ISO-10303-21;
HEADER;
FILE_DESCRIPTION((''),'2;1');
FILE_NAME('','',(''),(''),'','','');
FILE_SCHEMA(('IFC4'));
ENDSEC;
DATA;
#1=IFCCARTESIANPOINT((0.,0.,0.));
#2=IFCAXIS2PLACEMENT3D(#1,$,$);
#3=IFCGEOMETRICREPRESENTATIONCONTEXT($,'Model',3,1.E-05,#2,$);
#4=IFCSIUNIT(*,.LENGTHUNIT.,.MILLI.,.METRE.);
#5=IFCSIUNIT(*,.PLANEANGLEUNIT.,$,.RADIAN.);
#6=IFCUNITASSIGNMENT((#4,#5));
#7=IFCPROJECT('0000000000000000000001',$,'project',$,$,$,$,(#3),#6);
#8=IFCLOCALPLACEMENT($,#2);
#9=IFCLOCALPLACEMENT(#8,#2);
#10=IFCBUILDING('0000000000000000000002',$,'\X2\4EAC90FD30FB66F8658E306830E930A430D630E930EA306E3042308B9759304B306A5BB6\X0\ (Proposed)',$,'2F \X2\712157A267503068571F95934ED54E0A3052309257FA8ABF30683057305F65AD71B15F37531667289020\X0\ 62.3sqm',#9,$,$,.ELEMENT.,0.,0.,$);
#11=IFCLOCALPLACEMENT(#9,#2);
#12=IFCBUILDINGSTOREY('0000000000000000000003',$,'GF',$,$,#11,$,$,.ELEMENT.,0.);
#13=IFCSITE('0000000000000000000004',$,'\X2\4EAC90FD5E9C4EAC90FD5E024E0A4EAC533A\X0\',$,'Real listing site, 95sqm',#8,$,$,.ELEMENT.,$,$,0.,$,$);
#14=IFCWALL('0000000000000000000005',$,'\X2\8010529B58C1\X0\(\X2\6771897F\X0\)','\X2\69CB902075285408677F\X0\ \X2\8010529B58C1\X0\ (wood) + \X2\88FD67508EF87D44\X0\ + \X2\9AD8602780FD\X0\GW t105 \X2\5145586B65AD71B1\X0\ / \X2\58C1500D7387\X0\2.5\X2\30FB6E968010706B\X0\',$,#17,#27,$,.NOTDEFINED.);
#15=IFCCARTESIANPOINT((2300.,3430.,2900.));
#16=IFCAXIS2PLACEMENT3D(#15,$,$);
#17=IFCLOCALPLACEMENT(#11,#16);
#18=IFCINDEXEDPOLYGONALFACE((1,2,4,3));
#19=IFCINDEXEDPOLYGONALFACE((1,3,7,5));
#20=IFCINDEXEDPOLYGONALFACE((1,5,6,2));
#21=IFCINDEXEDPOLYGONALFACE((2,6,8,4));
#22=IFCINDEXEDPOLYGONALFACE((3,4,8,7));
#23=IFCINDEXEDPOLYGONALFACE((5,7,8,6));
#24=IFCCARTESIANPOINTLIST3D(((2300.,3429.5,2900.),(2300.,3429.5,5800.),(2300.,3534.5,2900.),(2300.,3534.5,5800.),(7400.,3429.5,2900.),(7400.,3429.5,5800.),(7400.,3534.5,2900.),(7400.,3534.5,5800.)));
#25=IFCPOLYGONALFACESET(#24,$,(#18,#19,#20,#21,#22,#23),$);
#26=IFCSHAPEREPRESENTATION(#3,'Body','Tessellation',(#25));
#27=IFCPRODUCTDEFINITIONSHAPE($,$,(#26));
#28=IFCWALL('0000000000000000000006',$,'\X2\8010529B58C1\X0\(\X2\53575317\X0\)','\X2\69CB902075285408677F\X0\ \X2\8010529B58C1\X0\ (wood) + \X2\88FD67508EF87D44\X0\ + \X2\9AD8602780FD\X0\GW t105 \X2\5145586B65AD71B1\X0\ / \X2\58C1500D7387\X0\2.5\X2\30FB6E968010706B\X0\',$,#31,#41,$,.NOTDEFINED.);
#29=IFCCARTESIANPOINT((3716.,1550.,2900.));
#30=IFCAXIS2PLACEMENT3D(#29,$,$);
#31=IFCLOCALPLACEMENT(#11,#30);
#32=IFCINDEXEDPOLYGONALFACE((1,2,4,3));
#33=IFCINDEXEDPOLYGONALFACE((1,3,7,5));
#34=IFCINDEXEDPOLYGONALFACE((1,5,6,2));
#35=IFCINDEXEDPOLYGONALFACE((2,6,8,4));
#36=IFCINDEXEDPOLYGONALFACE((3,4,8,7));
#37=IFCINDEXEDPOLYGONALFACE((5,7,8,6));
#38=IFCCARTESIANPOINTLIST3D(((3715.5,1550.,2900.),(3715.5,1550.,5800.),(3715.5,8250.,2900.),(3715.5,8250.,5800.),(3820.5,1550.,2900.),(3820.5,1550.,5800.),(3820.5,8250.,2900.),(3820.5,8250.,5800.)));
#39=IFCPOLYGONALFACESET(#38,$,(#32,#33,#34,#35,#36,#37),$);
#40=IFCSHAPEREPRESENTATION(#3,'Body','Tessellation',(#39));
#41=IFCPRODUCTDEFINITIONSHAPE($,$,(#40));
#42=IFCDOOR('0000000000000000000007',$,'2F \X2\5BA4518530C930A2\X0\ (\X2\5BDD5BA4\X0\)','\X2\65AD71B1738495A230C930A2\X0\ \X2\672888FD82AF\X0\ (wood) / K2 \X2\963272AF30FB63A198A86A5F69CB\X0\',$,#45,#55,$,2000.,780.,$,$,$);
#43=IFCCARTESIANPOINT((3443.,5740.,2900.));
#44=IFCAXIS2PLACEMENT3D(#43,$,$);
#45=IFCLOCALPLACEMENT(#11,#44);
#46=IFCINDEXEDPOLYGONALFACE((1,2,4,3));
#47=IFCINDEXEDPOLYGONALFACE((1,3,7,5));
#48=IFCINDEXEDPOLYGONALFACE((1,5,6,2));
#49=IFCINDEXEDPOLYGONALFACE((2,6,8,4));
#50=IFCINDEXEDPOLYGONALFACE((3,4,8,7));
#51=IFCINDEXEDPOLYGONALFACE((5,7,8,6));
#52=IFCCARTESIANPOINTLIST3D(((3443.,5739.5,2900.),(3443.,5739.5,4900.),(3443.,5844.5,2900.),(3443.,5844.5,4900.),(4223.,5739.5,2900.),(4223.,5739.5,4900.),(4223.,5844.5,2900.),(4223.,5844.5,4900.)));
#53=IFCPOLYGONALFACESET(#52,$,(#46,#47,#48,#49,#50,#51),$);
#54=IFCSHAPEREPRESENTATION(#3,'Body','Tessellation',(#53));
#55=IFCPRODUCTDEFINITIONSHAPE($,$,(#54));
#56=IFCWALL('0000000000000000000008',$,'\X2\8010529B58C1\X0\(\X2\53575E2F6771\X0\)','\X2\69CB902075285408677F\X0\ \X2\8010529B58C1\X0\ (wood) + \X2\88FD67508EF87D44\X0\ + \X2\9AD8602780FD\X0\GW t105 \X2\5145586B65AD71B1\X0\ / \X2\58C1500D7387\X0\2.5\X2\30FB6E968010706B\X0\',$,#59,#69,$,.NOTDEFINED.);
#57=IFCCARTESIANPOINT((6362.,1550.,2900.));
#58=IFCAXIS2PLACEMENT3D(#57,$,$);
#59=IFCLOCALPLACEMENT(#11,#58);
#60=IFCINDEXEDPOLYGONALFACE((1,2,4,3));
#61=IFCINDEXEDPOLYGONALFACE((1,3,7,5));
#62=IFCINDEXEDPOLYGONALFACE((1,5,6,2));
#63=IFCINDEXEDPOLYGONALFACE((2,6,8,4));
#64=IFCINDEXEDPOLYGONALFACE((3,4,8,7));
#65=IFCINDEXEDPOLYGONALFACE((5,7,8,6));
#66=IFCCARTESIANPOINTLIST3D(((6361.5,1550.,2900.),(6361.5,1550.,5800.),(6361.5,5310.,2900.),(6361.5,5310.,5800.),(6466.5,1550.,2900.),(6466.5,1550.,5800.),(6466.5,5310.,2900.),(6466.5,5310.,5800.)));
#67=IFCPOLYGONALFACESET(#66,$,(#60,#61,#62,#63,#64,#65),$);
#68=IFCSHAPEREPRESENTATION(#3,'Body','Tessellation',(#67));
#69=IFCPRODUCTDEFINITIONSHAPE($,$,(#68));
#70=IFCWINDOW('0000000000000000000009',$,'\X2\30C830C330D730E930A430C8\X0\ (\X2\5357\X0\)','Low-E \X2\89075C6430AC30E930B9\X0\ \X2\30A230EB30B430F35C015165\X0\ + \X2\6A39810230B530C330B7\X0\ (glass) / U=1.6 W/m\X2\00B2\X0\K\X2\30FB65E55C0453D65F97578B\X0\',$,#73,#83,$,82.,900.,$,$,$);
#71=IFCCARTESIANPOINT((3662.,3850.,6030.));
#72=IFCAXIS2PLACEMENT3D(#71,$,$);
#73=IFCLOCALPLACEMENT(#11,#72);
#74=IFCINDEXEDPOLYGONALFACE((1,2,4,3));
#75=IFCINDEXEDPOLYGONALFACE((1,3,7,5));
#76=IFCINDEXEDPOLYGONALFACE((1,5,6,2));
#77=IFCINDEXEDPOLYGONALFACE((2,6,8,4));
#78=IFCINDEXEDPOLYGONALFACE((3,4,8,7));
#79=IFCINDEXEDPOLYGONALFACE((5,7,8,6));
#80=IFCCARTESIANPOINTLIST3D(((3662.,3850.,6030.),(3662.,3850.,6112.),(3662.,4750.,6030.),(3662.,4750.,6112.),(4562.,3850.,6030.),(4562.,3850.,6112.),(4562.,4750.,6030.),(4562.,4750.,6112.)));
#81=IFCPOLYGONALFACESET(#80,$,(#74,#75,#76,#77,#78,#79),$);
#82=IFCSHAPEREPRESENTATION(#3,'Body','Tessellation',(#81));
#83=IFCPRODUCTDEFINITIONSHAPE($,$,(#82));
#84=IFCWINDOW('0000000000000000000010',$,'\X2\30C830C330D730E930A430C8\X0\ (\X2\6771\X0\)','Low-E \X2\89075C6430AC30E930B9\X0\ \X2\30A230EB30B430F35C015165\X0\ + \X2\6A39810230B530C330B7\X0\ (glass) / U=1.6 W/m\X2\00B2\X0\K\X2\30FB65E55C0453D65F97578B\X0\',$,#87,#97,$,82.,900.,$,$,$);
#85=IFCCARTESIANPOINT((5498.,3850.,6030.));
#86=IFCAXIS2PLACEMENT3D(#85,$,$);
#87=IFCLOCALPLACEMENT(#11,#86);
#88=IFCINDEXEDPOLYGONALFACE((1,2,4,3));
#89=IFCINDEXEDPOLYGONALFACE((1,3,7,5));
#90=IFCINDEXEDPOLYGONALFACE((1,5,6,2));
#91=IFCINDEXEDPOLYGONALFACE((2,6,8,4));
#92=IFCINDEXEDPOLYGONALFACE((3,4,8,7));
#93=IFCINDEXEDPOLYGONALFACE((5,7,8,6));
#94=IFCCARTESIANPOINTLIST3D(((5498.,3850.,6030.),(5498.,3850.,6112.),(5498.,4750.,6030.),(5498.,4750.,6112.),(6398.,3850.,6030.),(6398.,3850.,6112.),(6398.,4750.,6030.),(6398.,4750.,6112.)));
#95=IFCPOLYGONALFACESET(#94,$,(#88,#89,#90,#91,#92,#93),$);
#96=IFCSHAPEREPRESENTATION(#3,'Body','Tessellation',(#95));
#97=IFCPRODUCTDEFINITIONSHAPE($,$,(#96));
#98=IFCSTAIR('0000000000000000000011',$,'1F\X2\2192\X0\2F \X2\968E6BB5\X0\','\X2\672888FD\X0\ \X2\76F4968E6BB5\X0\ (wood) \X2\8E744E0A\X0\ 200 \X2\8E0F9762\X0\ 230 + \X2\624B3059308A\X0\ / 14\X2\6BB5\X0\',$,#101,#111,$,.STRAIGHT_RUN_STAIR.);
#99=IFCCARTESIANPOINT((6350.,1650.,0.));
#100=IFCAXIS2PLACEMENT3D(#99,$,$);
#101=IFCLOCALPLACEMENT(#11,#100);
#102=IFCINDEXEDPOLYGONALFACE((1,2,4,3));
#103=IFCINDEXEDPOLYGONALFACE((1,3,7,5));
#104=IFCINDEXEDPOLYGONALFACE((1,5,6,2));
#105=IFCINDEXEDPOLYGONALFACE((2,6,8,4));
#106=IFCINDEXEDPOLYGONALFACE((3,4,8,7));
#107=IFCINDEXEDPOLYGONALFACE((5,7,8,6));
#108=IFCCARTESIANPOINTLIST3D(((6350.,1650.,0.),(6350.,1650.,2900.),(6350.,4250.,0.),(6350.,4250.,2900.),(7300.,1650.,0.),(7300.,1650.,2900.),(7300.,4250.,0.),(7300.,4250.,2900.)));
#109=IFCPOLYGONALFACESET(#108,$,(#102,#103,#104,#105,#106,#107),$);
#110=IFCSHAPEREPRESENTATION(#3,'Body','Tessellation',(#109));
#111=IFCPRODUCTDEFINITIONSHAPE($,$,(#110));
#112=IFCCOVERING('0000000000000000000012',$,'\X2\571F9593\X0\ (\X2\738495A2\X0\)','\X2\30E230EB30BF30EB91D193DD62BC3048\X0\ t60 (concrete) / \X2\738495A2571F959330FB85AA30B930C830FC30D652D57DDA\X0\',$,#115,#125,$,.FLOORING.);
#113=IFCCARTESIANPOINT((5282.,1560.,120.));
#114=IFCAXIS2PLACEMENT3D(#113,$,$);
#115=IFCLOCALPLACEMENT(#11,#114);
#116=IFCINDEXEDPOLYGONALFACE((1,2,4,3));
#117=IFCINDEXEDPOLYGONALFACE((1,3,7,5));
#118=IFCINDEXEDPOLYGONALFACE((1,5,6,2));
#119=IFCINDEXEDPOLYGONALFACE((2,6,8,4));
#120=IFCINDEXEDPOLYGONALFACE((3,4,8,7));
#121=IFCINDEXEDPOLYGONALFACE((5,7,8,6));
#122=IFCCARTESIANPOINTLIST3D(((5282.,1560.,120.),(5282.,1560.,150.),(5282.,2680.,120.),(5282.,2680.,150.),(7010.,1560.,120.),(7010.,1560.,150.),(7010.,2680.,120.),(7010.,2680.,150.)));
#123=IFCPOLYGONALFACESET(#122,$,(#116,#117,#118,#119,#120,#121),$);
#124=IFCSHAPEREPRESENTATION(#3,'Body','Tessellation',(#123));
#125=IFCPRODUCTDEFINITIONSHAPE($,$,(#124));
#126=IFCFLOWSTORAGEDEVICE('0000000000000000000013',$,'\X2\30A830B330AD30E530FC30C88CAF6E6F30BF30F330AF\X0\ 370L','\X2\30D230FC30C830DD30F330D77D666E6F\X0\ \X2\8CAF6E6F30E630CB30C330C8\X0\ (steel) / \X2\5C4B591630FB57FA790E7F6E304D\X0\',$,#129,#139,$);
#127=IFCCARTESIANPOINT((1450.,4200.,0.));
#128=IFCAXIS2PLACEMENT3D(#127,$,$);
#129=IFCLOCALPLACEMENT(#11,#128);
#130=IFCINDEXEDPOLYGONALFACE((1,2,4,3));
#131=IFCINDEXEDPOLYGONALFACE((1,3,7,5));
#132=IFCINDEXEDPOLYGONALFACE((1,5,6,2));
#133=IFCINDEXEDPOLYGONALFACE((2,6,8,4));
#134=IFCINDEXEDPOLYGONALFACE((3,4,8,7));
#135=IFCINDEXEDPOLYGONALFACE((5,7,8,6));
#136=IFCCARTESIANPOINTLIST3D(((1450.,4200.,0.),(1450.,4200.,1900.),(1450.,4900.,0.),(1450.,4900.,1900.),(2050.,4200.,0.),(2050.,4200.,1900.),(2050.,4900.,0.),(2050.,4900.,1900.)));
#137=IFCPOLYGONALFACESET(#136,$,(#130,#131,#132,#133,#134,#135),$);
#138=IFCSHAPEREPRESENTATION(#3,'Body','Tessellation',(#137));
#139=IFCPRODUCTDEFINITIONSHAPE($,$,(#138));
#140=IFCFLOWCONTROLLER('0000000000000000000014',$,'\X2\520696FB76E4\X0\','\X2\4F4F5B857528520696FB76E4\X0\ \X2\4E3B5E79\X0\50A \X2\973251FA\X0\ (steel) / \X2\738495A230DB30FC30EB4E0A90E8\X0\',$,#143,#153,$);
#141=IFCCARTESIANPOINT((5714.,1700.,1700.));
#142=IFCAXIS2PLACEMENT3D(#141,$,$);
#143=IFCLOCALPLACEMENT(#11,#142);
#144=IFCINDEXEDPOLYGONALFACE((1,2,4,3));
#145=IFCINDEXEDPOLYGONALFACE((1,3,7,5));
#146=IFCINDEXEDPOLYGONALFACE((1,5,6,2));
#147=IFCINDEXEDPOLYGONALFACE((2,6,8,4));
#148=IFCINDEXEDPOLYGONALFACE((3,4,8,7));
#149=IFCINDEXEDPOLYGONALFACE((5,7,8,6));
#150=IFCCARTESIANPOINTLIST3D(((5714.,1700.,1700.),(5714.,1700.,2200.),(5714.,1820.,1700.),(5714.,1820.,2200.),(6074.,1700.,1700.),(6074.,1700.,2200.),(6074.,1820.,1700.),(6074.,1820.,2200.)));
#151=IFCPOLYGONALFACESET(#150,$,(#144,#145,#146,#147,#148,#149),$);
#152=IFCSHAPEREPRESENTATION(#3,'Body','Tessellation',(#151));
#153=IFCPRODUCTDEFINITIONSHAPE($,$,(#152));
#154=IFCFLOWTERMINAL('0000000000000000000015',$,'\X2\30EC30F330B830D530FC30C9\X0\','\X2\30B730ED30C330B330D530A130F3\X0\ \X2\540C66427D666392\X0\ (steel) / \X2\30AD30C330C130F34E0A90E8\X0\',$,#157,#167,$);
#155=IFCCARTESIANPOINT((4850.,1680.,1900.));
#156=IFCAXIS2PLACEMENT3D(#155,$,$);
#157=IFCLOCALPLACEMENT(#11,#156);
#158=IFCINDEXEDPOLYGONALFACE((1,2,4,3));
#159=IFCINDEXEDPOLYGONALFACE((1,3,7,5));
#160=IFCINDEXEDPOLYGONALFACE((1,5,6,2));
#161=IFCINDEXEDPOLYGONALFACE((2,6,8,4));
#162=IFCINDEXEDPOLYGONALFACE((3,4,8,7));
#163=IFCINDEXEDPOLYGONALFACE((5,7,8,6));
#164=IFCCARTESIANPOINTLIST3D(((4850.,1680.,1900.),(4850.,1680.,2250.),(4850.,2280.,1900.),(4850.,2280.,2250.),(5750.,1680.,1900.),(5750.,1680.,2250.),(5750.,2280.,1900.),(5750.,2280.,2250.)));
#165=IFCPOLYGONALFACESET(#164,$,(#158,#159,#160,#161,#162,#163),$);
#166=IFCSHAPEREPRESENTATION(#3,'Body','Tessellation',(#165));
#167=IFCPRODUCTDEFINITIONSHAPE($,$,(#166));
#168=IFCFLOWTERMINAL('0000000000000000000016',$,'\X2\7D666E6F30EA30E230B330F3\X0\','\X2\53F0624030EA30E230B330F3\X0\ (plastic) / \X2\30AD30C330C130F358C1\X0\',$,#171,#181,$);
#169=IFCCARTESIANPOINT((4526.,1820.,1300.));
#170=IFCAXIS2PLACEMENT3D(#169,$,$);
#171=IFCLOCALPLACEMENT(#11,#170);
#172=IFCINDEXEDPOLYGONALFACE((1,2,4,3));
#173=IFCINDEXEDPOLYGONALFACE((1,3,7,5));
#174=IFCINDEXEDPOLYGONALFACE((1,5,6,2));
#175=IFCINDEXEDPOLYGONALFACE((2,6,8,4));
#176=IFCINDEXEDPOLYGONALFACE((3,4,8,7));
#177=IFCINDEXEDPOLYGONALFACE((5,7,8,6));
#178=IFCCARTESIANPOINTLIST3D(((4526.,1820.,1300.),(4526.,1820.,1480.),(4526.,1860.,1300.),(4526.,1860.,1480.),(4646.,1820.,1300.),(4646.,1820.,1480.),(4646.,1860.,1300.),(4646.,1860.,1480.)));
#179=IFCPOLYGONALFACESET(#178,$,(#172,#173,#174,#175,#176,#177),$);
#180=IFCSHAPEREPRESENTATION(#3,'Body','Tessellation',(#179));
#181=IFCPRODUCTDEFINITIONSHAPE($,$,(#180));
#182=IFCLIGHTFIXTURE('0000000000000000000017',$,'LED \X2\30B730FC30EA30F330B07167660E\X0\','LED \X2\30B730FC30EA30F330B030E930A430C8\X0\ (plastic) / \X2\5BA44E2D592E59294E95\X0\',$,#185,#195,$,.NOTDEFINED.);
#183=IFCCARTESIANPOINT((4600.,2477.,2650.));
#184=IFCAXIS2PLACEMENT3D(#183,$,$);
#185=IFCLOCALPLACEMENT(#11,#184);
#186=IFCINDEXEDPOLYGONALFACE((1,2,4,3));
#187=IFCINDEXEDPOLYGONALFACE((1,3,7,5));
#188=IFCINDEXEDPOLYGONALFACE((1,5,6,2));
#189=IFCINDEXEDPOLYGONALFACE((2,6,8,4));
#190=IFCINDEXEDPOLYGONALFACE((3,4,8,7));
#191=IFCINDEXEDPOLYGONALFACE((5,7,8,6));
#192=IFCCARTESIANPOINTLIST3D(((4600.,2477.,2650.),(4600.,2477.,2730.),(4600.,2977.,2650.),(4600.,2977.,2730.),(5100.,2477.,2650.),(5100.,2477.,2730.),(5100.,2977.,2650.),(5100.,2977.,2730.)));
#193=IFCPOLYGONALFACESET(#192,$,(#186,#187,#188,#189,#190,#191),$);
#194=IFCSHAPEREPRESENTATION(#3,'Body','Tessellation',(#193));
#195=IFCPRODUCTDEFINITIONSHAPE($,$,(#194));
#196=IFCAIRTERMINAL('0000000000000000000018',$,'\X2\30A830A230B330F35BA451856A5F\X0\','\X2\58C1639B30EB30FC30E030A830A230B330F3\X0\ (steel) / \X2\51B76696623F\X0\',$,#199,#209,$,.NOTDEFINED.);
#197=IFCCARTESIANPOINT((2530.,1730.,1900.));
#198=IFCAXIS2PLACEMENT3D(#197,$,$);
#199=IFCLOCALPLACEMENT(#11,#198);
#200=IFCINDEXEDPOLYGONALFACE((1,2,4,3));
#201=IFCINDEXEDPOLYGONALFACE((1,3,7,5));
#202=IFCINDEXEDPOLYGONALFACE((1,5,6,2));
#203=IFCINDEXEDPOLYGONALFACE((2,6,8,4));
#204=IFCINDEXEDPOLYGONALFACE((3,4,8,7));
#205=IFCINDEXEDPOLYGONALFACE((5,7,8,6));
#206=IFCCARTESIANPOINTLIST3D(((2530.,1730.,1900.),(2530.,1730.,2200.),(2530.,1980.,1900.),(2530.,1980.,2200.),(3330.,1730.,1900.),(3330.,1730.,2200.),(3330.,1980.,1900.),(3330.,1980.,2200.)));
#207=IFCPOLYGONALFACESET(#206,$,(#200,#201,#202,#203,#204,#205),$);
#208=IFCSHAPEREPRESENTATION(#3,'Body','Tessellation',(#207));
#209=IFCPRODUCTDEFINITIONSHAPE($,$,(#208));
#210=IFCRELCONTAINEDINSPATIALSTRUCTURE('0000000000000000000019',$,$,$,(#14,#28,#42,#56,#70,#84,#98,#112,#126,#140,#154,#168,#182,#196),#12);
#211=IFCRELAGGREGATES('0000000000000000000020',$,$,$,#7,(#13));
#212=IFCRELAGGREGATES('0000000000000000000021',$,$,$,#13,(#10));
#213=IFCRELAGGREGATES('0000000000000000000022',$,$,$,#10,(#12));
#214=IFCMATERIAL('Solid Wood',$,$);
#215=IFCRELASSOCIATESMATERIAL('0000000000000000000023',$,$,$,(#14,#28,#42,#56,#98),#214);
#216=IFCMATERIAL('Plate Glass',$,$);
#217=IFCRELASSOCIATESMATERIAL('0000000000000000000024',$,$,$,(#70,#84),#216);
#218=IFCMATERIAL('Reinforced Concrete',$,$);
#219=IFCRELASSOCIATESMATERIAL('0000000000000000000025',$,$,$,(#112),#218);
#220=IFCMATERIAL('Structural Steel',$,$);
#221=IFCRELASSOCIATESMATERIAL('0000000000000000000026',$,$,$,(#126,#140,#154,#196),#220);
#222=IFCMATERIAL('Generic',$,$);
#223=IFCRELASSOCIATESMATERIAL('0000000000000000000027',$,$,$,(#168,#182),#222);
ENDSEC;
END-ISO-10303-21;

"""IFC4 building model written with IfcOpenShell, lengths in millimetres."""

from ifc_helpers import new_model, si_unit, frame, frame_2d, origin, place, context, project, spatial, rectangle, extrude, material, element, fill, save


model = new_model("IFC4")

# Units and contexts
model_context = context("Model", 3, precision=1e-05, world=origin())
ifc_project = project(units=[si_unit("LENGTHUNIT", "METRE", prefix="MILLI"), si_unit("PLANEANGLEUNIT", "RADIAN")], contexts=[model_context])

# Site, building, storey
site_placement = place(None, origin())
site = spatial("IfcSite", under=ifc_project, at=site_placement, Name="京都府京都市上京区", ObjectType="Real listing site, 95sqm", CompositionType="ELEMENT", RefElevation=0.0)
building_placement = place(site_placement, origin())
building = spatial("IfcBuilding", under=site, at=building_placement, Name="京都・書斎とライブラリのある静かな家 (Proposed)", ObjectType="2F 無垢材と土間仕上げを基調とした断熱強化木造 62.3sqm", CompositionType="ELEMENT", ElevationOfRefHeight=0.0, ElevationOfTerrain=0.0)
storey_placement = place(building_placement, origin())
storey = spatial("IfcBuildingStorey", under=building, at=storey_placement, Name="GF", CompositionType="ELEMENT", Elevation=0.0)

# Shared definitions
ifc_material_1 = material(Name="Solid Wood")

# Wall
wall_1_placement = place(storey_placement, frame((2300.0, 3430.0, 2900.0)))
element("IfcWall", 1, at=wall_1_placement, inside=storey, material=ifc_material_1, Name="耐力壁(東西)", Description="構造用合板 耐力壁 (wood) + 製材軸組 + 高性能GW t105 充填断熱 / 壁倍率2.5・準耐火", PredefinedType="NOTDEFINED", context=model_context, shape_type="SweptSolid", body=[
    extrude(rectangle(XDim=5100.0, YDim=105.0, at=frame_2d((2550.0, 52.0))), frame((2300.0, 3430.0, 2900.0)), (0.0, 0.0, 1.0), 2900.0),
])

# Wall, opening, door
wall_2_placement = place(storey_placement, frame((3716.0, 1550.0, 2900.0)))
wall_2 = element("IfcWall", 2, at=wall_2_placement, inside=storey, material=ifc_material_1, Name="耐力壁(南北)", Description="構造用合板 耐力壁 (wood) + 製材軸組 + 高性能GW t105 充填断熱 / 壁倍率2.5・準耐火", PredefinedType="NOTDEFINED", context=model_context, shape_type="SweptSolid", body=[
    extrude(rectangle(XDim=105.0, YDim=6700.0, at=frame_2d((52.0, 3350.0))), frame((3716.0, 1550.0, 2900.0)), (0.0, 0.0, 1.0), 2900.0),
])
opening_placement = place(storey_placement, frame((3443.0, 5740.0, 2900.0)))
opening = element("IfcOpeningElement", 3, at=opening_placement, cuts=wall_2, PredefinedType="NOTDEFINED", context=model_context, shape_type="SweptSolid", body=[
    extrude(rectangle(XDim=780.0, YDim=105.0, at=frame_2d((390.0, 52.0))), frame((3443.0, 5740.0, 2900.0)), (0.0, 0.0, 1.0), 2000.0),
])
door_placement = place(storey_placement, frame((3443.0, 5740.0, 2900.0)))
door = element("IfcDoor", 4, at=door_placement, inside=storey, material=ifc_material_1, Name="2F 室内ドア (寝室)", Description="断熱玄関ドア 木製芯 (wood) / K2 防犯・採風機構", OverallHeight=2000.0, OverallWidth=780.0, context=model_context, shape_type="SweptSolid", body=[
    extrude(rectangle(XDim=780.0, YDim=105.0, at=frame_2d((390.0, 52.0))), frame((3443.0, 5740.0, 2900.0)), (0.0, 0.0, 1.0), 2000.0),
])
fill(opening, door)

# Wall
wall_3_placement = place(storey_placement, frame((6362.0, 1550.0, 2900.0)))
element("IfcWall", 5, at=wall_3_placement, inside=storey, material=ifc_material_1, Name="耐力壁(南帯東)", Description="構造用合板 耐力壁 (wood) + 製材軸組 + 高性能GW t105 充填断熱 / 壁倍率2.5・準耐火", PredefinedType="NOTDEFINED", context=model_context, shape_type="SweptSolid", body=[
    extrude(rectangle(XDim=105.0, YDim=3760.0, at=frame_2d((52.0, 1880.0))), frame((6362.0, 1550.0, 2900.0)), (0.0, 0.0, 1.0), 2900.0),
])

# Windows
ifc_material_2 = material(Name="Plate Glass")
window_1_placement = place(storey_placement, frame((3662.0, 3850.0, 6030.0)))
element("IfcWindow", 6, at=window_1_placement, inside=storey, material=ifc_material_2, Name="トップライト (南)", Description="Low-E 複層ガラス アルゴン封入 + 樹脂サッシ (glass) / U=1.6 W/m²K・日射取得型", OverallHeight=82.0, OverallWidth=900.0, context=model_context, shape_type="SweptSolid", body=[
    extrude(rectangle(XDim=900.0, YDim=900.0, at=frame_2d((450.0, 450.0))), frame((3662.0, 3850.0, 6030.0)), (0.0, 0.0, 1.0), 82.0),
])
window_2_placement = place(storey_placement, frame((5498.0, 3850.0, 6030.0)))
element("IfcWindow", 7, at=window_2_placement, inside=storey, material=ifc_material_2, Name="トップライト (東)", Description="Low-E 複層ガラス アルゴン封入 + 樹脂サッシ (glass) / U=1.6 W/m²K・日射取得型", OverallHeight=82.0, OverallWidth=900.0, context=model_context, shape_type="SweptSolid", body=[
    extrude(rectangle(XDim=900.0, YDim=900.0, at=frame_2d((450.0, 450.0))), frame((5498.0, 3850.0, 6030.0)), (0.0, 0.0, 1.0), 82.0),
])

# Stair
stair_placement = place(storey_placement, frame((6350.0, 1650.0, 0.0)))
element("IfcStair", 8, at=stair_placement, inside=storey, material=ifc_material_1, Name="1F→2F 階段", Description="木製 直階段 (wood) 蹴上 200 踏面 230 + 手すり / 14段", PredefinedType="STRAIGHT_RUN_STAIR", context=model_context, shape_type="SweptSolid", body=[
    extrude(rectangle(XDim=950.0, YDim=2600.0, at=frame_2d((475.0, 1300.0))), frame((6350.0, 1650.0, 0.0)), (0.0, 0.0, 1.0), 2900.0),
])

# Covering
ifc_material_3 = material(Name="Reinforced Concrete")
covering_placement = place(storey_placement, frame((5282.0, 1560.0, 120.0)))
element("IfcCovering", 9, at=covering_placement, inside=storey, material=ifc_material_3, Name="土間 (玄関)", Description="モルタル金鏝押え t60 (concrete) / 玄関土間・薪ストーブ動線", PredefinedType="FLOORING", context=model_context, shape_type="SweptSolid", body=[
    extrude(rectangle(XDim=1728.0, YDim=1120.0, at=frame_2d((864.0, 560.0))), frame((5282.0, 1560.0, 120.0)), (0.0, 0.0, 1.0), 30.0),
])

# Flow storage device
ifc_material_4 = material(Name="Structural Steel")
flow_storage_device_placement = place(storey_placement, frame((1450.0, 4200.0, 0.0)))
element("IfcFlowStorageDevice", 10, at=flow_storage_device_placement, inside=storey, material=ifc_material_4, Name="エコキュート貯湯タンク 370L", Description="ヒートポンプ給湯 貯湯ユニット (steel) / 屋外・基礎置き", context=model_context, shape_type="SweptSolid", body=[
    extrude(rectangle(XDim=600.0, YDim=700.0, at=frame_2d((300.0, 350.0))), frame((1450.0, 4200.0, 0.0)), (0.0, 0.0, 1.0), 1900.0),
])

# Flow controller
flow_controller_placement = place(storey_placement, frame((5714.0, 1700.0, 1700.0)))
element("IfcFlowController", 11, at=flow_controller_placement, inside=storey, material=ifc_material_4, Name="分電盤", Description="住宅用分電盤 主幹50A 露出 (steel) / 玄関ホール上部", context=model_context, shape_type="SweptSolid", body=[
    extrude(rectangle(XDim=360.0, YDim=120.0, at=frame_2d((180.0, 60.0))), frame((5714.0, 1700.0, 1700.0)), (0.0, 0.0, 1.0), 500.0),
])

# Flow terminals
flow_terminal_1_placement = place(storey_placement, frame((4850.0, 1680.0, 1900.0)))
element("IfcFlowTerminal", 12, at=flow_terminal_1_placement, inside=storey, material=ifc_material_4, Name="レンジフード", Description="シロッコファン 同時給排 (steel) / キッチン上部", context=model_context, shape_type="SweptSolid", body=[
    extrude(rectangle(XDim=900.0, YDim=600.0, at=frame_2d((450.0, 300.0))), frame((4850.0, 1680.0, 1900.0)), (0.0, 0.0, 1.0), 350.0),
])
ifc_material_5 = material(Name="Generic")
flow_terminal_2_placement = place(storey_placement, frame((4526.0, 1820.0, 1300.0)))
element("IfcFlowTerminal", 13, at=flow_terminal_2_placement, inside=storey, material=ifc_material_5, Name="給湯リモコン", Description="台所リモコン (plastic) / キッチン壁", context=model_context, shape_type="SweptSolid", body=[
    extrude(rectangle(XDim=120.0, YDim=40.0, at=frame_2d((60.0, 20.0))), frame((4526.0, 1820.0, 1300.0)), (0.0, 0.0, 1.0), 180.0),
])

# Light fixture
light_fixture_1_placement = place(storey_placement, frame((4600.0, 2477.0, 2650.0)))
element("IfcLightFixture", 14, at=light_fixture_1_placement, inside=storey, material=ifc_material_5, Name="LED シーリング照明", Description="LED シーリングライト (plastic) / 室中央天井", PredefinedType="NOTDEFINED", context=model_context, shape_type="SweptSolid", body=[
    extrude(rectangle(XDim=500.0, YDim=500.0, at=frame_2d((250.0, 250.0))), frame((4600.0, 2477.0, 2650.0)), (0.0, 0.0, 1.0), 80.0),
])

# Air terminal
air_terminal_1_placement = place(storey_placement, frame((2530.0, 1730.0, 1900.0)))
element("IfcAirTerminal", 15, at=air_terminal_1_placement, inside=storey, material=ifc_material_4, Name="エアコン室内機", Description="壁掛ルームエアコン (steel) / 冷暖房", PredefinedType="NOTDEFINED", context=model_context, shape_type="SweptSolid", body=[
    extrude(rectangle(XDim=800.0, YDim=250.0, at=frame_2d((400.0, 125.0))), frame((2530.0, 1730.0, 1900.0)), (0.0, 0.0, 1.0), 300.0),
])

save(model, "model.ifc")
